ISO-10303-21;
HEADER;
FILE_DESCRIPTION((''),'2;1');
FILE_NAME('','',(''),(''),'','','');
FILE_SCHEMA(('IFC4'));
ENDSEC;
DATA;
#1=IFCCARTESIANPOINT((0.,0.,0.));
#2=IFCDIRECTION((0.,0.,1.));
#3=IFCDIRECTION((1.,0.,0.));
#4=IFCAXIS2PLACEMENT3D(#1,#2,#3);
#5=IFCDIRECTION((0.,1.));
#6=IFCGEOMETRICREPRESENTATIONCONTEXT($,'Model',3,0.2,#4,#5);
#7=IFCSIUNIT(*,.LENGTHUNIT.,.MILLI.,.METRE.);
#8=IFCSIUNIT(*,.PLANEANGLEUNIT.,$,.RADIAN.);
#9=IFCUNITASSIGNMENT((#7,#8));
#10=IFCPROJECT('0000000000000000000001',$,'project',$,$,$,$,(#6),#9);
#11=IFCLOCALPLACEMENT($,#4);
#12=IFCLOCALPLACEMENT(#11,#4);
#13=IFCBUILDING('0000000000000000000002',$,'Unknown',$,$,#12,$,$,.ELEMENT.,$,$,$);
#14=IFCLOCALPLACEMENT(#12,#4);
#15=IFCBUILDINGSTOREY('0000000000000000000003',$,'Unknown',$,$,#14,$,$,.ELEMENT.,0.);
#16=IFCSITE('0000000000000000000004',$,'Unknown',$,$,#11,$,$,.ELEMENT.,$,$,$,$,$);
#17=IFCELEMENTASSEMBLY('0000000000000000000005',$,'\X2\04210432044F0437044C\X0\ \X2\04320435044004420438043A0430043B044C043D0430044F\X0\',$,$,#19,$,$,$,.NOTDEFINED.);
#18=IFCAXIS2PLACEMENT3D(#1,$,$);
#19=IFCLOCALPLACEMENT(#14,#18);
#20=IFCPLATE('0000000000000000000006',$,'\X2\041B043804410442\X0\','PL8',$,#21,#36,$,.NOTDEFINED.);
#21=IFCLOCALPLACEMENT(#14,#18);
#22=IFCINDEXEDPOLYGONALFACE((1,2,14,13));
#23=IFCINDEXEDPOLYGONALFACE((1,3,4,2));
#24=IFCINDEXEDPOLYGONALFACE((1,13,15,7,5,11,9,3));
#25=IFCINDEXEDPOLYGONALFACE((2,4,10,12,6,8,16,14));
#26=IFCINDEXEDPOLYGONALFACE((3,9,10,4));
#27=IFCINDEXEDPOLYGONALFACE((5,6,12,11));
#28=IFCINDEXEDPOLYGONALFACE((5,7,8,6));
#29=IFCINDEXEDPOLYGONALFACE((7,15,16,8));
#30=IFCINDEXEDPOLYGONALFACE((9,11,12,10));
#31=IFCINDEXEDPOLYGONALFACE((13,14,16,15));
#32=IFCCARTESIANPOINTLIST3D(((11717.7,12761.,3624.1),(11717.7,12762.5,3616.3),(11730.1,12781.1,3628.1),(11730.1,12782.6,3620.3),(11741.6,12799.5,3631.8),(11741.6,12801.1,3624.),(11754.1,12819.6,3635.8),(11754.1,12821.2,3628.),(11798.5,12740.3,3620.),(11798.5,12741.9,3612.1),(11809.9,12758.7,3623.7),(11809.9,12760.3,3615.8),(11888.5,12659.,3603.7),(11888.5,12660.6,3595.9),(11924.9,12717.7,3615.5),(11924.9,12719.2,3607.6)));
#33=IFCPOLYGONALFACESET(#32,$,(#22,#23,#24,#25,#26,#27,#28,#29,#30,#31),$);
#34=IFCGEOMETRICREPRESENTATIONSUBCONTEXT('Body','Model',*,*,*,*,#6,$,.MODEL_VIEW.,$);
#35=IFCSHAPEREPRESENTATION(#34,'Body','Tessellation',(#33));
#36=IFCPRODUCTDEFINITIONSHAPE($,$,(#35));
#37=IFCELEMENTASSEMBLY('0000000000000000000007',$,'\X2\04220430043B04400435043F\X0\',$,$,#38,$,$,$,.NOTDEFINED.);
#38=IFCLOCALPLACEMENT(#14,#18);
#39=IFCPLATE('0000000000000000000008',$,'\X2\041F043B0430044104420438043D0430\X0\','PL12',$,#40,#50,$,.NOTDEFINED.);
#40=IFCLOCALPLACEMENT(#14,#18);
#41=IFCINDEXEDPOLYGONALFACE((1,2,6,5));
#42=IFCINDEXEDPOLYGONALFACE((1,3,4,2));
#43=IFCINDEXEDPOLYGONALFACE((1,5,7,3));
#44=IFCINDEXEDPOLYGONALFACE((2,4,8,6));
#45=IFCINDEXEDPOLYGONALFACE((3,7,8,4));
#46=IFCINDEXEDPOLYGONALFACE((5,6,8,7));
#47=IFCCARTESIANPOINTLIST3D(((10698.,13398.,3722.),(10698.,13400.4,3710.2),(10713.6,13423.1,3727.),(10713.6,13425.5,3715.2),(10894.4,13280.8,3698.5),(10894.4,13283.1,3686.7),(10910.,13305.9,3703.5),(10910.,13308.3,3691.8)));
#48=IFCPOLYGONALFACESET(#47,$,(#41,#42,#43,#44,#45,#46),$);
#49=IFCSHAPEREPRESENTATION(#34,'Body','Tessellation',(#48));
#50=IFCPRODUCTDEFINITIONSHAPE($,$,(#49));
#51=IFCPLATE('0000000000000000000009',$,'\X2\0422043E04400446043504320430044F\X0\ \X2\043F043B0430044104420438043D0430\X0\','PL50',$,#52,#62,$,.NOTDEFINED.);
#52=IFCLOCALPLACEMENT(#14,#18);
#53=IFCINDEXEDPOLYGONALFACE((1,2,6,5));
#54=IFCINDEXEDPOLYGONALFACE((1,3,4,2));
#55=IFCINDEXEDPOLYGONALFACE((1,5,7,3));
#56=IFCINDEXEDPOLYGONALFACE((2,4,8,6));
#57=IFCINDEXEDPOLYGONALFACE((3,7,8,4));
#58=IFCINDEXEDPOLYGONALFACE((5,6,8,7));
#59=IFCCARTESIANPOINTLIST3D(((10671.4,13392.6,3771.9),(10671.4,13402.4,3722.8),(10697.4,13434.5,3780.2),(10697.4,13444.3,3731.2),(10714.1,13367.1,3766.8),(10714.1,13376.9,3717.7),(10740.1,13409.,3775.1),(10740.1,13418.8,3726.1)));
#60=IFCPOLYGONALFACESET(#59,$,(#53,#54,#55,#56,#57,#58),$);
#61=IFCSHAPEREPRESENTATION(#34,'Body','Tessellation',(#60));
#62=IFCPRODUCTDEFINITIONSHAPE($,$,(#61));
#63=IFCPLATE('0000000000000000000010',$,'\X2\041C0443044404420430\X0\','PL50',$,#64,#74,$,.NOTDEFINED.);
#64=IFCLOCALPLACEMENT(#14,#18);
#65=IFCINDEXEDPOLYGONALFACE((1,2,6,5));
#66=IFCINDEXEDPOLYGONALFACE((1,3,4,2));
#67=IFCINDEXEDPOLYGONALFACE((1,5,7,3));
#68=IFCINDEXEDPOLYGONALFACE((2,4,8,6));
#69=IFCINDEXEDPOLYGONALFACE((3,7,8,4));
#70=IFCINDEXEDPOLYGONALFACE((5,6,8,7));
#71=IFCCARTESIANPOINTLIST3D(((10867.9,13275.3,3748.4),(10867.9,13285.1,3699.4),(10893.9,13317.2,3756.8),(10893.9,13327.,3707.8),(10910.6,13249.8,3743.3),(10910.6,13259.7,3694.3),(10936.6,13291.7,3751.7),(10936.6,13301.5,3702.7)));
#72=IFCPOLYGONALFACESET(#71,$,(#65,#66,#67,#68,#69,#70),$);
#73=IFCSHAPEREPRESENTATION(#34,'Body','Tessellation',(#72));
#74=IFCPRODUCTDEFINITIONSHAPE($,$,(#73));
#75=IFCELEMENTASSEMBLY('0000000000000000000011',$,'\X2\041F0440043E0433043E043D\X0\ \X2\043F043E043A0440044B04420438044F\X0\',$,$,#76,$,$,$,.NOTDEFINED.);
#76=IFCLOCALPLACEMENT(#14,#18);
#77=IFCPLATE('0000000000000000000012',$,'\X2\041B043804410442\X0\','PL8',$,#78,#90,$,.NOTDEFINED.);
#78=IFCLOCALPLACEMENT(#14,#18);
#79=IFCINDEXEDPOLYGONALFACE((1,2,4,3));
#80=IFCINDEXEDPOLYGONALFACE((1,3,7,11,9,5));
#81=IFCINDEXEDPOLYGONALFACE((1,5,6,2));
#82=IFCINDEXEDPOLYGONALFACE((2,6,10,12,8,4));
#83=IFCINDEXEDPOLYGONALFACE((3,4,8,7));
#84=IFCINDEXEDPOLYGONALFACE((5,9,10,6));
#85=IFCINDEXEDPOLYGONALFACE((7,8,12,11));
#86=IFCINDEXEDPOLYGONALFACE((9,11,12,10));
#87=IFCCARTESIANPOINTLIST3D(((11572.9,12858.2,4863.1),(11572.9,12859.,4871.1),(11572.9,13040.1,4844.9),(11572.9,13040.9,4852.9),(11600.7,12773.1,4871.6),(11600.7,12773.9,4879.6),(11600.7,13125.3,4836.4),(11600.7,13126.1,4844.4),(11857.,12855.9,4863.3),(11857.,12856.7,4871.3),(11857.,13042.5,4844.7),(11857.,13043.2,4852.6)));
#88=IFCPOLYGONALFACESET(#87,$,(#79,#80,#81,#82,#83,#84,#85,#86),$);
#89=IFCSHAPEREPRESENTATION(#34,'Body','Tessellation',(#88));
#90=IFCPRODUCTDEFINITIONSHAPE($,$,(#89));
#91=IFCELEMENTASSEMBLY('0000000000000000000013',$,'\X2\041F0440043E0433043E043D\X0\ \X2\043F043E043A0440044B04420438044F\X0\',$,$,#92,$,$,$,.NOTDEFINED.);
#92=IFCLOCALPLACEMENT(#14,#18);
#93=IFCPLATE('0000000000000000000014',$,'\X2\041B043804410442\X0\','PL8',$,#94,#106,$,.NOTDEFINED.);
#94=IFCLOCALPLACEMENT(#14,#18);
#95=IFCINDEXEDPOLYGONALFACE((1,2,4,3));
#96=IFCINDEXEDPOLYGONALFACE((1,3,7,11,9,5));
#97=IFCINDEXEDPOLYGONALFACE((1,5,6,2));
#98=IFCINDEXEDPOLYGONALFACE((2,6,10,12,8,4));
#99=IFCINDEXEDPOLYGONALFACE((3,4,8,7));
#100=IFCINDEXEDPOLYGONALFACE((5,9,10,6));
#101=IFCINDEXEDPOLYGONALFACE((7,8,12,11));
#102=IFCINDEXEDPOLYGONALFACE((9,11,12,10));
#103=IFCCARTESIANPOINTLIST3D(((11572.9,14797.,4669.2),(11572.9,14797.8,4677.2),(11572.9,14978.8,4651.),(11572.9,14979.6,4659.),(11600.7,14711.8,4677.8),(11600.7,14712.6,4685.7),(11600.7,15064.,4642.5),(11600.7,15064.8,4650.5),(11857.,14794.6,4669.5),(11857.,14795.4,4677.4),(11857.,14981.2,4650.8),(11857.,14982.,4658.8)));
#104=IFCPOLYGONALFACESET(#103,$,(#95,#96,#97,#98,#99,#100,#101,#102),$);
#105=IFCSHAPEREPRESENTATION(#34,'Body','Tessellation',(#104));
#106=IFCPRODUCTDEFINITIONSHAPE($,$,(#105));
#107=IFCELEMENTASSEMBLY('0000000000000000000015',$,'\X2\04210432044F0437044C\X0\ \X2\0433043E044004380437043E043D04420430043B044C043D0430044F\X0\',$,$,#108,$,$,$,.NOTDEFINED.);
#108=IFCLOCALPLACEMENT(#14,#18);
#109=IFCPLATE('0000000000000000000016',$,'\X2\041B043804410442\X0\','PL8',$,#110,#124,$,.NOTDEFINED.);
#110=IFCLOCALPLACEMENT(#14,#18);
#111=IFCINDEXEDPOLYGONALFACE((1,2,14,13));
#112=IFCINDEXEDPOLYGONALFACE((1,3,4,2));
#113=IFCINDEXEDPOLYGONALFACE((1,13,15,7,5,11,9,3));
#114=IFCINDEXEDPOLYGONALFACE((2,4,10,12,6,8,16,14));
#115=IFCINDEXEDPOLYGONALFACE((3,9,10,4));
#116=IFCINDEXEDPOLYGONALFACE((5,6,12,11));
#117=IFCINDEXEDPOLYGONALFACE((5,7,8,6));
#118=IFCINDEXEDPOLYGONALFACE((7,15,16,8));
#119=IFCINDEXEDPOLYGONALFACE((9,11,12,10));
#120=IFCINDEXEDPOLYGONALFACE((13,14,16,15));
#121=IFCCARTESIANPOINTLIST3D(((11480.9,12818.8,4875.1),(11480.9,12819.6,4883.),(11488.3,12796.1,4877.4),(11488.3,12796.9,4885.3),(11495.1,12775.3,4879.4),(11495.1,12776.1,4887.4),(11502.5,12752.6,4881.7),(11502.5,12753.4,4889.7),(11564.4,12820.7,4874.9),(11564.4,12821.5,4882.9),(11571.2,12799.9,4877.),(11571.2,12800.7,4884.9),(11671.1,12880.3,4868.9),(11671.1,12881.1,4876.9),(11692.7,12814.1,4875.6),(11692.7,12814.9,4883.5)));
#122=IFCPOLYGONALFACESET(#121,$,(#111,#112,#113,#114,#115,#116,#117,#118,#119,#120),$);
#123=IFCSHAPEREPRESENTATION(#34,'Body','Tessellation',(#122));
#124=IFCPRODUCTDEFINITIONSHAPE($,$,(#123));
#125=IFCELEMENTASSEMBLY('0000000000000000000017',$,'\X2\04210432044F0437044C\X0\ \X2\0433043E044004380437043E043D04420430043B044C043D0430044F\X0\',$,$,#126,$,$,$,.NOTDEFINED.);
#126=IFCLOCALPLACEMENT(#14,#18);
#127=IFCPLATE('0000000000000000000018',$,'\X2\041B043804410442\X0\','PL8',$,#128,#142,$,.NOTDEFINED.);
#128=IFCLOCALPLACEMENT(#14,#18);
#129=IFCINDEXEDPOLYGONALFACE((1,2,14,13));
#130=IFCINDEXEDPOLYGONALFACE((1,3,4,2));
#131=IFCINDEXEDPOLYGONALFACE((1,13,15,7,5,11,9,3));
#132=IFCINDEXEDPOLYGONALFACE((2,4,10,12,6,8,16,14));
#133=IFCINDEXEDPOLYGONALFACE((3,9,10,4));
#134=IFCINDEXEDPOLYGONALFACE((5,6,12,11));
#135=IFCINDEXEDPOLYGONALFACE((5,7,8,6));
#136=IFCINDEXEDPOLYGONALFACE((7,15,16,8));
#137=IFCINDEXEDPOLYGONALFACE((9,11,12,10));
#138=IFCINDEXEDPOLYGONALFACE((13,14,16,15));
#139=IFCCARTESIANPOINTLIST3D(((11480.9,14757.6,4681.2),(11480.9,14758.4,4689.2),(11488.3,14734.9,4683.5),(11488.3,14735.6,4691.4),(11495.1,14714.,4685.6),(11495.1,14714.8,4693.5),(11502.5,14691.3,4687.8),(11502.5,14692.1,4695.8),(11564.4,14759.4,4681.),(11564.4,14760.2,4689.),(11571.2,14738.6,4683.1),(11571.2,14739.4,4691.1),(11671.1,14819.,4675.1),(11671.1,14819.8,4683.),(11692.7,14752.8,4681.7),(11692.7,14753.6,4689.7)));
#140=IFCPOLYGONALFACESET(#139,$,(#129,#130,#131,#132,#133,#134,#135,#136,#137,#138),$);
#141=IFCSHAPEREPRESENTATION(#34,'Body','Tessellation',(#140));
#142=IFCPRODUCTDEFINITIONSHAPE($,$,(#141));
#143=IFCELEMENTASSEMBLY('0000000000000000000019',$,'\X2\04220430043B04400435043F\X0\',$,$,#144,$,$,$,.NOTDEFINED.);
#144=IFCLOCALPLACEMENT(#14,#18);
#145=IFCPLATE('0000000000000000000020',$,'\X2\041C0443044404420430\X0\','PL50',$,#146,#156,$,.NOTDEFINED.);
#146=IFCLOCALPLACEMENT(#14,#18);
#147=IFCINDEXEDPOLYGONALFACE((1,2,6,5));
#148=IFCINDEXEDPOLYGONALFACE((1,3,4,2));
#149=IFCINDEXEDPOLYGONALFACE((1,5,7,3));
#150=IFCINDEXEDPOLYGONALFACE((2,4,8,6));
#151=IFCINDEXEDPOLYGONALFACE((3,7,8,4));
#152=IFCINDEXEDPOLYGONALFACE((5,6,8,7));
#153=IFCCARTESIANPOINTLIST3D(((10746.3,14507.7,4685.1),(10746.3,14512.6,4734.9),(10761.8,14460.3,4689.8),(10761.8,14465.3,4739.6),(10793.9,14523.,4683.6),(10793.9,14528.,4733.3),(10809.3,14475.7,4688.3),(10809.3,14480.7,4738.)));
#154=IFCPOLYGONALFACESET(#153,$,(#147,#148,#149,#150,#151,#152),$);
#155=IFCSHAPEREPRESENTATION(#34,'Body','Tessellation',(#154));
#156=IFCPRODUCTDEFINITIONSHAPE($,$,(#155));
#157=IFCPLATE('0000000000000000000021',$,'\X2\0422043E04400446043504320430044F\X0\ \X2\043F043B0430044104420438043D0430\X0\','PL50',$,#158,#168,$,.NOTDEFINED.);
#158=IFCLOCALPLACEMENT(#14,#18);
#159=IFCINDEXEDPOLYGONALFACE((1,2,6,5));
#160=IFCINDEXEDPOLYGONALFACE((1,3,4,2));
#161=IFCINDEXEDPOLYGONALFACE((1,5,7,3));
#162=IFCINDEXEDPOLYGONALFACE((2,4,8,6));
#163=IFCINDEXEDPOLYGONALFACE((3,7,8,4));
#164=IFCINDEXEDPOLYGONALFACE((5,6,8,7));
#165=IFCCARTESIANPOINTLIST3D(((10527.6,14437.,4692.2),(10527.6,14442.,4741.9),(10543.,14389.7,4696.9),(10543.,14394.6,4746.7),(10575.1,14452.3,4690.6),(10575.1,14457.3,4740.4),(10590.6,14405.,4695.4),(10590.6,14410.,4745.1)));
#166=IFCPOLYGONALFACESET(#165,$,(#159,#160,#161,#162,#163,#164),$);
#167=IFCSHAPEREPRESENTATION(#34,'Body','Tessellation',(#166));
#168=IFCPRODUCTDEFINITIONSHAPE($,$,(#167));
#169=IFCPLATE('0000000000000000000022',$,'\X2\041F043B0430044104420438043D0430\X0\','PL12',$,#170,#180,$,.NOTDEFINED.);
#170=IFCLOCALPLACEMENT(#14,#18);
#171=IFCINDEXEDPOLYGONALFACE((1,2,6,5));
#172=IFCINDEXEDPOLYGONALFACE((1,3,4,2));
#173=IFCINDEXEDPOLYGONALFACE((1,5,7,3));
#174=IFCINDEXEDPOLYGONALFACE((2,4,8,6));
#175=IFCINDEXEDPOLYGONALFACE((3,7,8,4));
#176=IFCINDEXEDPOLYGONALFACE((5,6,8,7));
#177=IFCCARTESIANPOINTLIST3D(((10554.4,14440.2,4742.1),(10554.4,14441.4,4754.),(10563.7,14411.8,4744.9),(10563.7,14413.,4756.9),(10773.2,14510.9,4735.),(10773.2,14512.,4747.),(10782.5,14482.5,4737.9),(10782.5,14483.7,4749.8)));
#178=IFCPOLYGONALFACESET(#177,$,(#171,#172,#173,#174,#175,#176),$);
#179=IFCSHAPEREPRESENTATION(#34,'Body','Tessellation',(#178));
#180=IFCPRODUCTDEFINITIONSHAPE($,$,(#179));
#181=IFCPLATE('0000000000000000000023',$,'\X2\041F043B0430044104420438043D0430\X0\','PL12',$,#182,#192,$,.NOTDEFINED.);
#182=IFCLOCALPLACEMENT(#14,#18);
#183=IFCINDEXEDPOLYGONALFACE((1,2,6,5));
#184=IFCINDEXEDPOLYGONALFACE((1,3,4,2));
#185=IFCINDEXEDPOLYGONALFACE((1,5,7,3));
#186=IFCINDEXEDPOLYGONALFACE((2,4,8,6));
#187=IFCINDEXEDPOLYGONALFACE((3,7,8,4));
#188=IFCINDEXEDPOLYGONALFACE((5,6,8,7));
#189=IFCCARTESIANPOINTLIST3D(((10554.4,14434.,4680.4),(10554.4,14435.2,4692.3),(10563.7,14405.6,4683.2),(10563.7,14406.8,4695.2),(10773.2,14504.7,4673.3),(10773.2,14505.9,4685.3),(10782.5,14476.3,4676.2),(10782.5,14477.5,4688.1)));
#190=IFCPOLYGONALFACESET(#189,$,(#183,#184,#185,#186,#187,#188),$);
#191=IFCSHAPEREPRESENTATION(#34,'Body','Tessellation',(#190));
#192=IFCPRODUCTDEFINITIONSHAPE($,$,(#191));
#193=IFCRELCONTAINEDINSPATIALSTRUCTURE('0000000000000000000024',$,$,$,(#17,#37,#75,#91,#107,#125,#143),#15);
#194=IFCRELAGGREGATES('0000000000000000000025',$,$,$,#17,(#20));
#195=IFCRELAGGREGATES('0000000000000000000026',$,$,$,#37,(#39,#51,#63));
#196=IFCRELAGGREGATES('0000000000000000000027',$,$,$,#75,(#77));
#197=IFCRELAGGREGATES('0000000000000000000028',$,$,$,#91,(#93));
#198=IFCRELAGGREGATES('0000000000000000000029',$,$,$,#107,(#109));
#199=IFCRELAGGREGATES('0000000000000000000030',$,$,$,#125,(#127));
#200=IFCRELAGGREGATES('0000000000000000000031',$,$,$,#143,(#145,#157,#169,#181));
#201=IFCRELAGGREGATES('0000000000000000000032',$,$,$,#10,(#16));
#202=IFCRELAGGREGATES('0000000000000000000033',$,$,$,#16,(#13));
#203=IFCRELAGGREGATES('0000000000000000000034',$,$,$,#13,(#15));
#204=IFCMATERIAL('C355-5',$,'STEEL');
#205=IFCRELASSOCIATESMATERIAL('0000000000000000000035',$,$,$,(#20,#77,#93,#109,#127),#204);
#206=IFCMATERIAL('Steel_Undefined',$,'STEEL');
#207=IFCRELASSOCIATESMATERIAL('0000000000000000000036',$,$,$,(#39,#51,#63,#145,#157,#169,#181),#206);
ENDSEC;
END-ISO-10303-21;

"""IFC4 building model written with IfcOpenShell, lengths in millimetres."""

from ifc_helpers import new_model, si_unit, direction, frame, origin_with_axes, place, context, subcontext, project, spatial, line, indexed_curve, outline, extrude, material, element, aggregate, save


model = new_model("IFC4")

# Units and contexts
model_context = context("Model", 3, precision=0.2, world=origin_with_axes(), true_north=direction((0.0, 1.0)))
body_context = subcontext(model_context, "Body", "Model", "MODEL_VIEW")
ifc_project = project(units=[si_unit("LENGTHUNIT", "METRE", prefix="MILLI"), si_unit("PLANEANGLEUNIT", "RADIAN")], contexts=[model_context])

# Site, building, storey
site_placement = place(None, origin_with_axes())
site = spatial("IfcSite", under=ifc_project, at=site_placement, Name="Unknown", CompositionType="ELEMENT")
building_placement = place(site_placement, origin_with_axes())
building = spatial("IfcBuilding", under=site, at=building_placement, Name="Unknown", CompositionType="ELEMENT")
storey_placement = place(building_placement, origin_with_axes())
storey = spatial("IfcBuildingStorey", under=building, at=storey_placement, Name="Unknown", CompositionType="ELEMENT", Elevation=0.0)

# Element assembly, plate
assembly_1_placement = place(storey_placement, frame((10804.0, 13347.1, 3737.3), z_axis=(0.519802, 0.837697, 0.167539), x_axis=(0.854287, -0.509708, -0.101942)))
assembly_1 = element("IfcElementAssembly", 1, at=assembly_1_placement, inside=storey, Name="Связь вертикальная", PredefinedType="NOTDEFINED")
ifc_material_1 = material(Name="C355-5", Category="STEEL")
plate_1_placement = place(assembly_1_placement, frame((1090.8, 0.0, 35.0), z_axis=(0.0, 1.0, 0.0), x_axis=(1.0, 0.0, 0.0)))
plate_1 = element("IfcPlate", 2, at=plate_1_placement, material=ifc_material_1, Name="Лист", Description="PL8", PredefinedType="NOTDEFINED", context=body_context, shape_type="SolidModel", body=[
    extrude(outline(indexed_curve([(0.0, 0.0), (200.0, 0.0), (200.0, 70.0), (0.0, 70.0), (0.0, 46.0), (80.0, 46.0), (80.0, 24.0), (0.0, 24.0)], segments=[line(1, 2, 3, 4, 5, 6, 7, 8, 1)])), frame((0.0, 0.0, 4.0), z_axis=(0.0, 0.0, 1.0), x_axis=(1.0, 0.0, 0.0)), (0.0, 0.0, -1.0), 8.0),
])
aggregate(assembly_1, [plate_1])

# Element assembly, plates
assembly_2_placement = place(storey_placement, frame((10915.2, 13314.3, 3705.2), z_axis=(-0.854287, 0.509708, 0.101942), x_axis=(-0.519802, -0.837697, -0.167539)))
assembly_2 = element("IfcElementAssembly", 3, at=assembly_2_placement, inside=storey, Name="Талреп", PredefinedType="NOTDEFINED")
ifc_material_2 = material(Name="Steel_Undefined", Category="STEEL")
plate_2_placement = place(assembly_2_placement, frame((10.0, -6.0, 230.0), z_axis=(0.0, 1.0, 0.0), x_axis=(1.0, 0.0, 0.0)))
plate_2 = element("IfcPlate", 4, at=plate_2_placement, material=ifc_material_2, Name="Пластина", Description="PL12", PredefinedType="NOTDEFINED", context=body_context, shape_type="SolidModel", body=[
    extrude(outline(indexed_curve([(0.0, 0.0), (30.0, 0.0), (30.0, 230.0), (0.0, 230.0)], segments=[line(1, 2, 3, 4, 1)])), frame((0.0, 0.0, 6.0), z_axis=(0.0, 0.0, 1.0), x_axis=(1.0, 0.0, 0.0)), (0.0, 0.0, -1.0), 12.0),
])
plate_3_placement = place(assembly_2_placement, frame((0.0, 0.0, 230.0), z_axis=(0.0, 0.0, 1.0), x_axis=(1.0, 0.0, 0.0)))
plate_3 = element("IfcPlate", 5, at=plate_3_placement, material=ifc_material_2, Name="Торцевая пластина", Description="PL50", PredefinedType="NOTDEFINED", context=body_context, shape_type="SolidModel", body=[
    extrude(outline(indexed_curve([(0.0, 0.0), (50.0, 0.0), (50.0, 50.0), (0.0, 50.0)], segments=[line(1, 2, 3, 4, 1)])), frame((0.0, 0.0, 25.0), z_axis=(0.0, 0.0, 1.0), x_axis=(1.0, 0.0, 0.0)), (0.0, 0.0, -1.0), 50.0),
])
plate_4_placement = place(assembly_2_placement, origin_with_axes())
plate_4 = element("IfcPlate", 6, at=plate_4_placement, material=ifc_material_2, Name="Муфта", Description="PL50", PredefinedType="NOTDEFINED", context=body_context, shape_type="SolidModel", body=[
    extrude(outline(indexed_curve([(0.0, 0.0), (50.0, 0.0), (50.0, 50.0), (0.0, 50.0)], segments=[line(1, 2, 3, 4, 1)])), frame((0.0, 0.0, 25.0), z_axis=(0.0, 0.0, 1.0), x_axis=(1.0, 0.0, 0.0)), (0.0, 0.0, -1.0), 50.0),
])
aggregate(assembly_2, [plate_2, plate_3, plate_4])

# Element assemblies, plates
assembly_3_placement = place(storey_placement, frame((12000.0, 12949.6, 4858.0), z_axis=(0.0, -0.995037, 0.099504), x_axis=(-1.0, 0.0, 0.0)))
assembly_3 = element("IfcElementAssembly", 7, at=assembly_3_placement, inside=storey, Name="Прогон покрытия", PredefinedType="NOTDEFINED")
plate_5_placement = place(assembly_3_placement, frame((427.1, 0.0, 91.4), z_axis=(0.0, -1.0, 0.0), x_axis=(-0.308855, 0.0, 0.951109)))
plate_5 = element("IfcPlate", 8, at=plate_5_placement, material=ifc_material_1, Name="Лист", Description="PL8", PredefinedType="NOTDEFINED", context=body_context, shape_type="SolidModel", body=[
    extrude(outline(indexed_curve([(0.0, 0.0), (90.0, 0.0), (90.0, 269.5), (-88.3, 327.4), (-246.6, 109.3), (-173.8, 56.4)], segments=[line(1, 2, 3, 4, 5, 6, 1)])), frame((0.0, 0.0, 4.0), z_axis=(0.0, 0.0, 1.0), x_axis=(1.0, 0.0, 0.0)), (0.0, 0.0, -1.0), 8.0),
])
aggregate(assembly_3, [plate_5])
assembly_4_placement = place(storey_placement, frame((12000.0, 14888.3, 4664.1), z_axis=(0.0, -0.995037, 0.099504), x_axis=(-1.0, 0.0, 0.0)))
assembly_4 = element("IfcElementAssembly", 9, at=assembly_4_placement, inside=storey, Name="Прогон покрытия", PredefinedType="NOTDEFINED")
plate_6_placement = place(assembly_4_placement, frame((427.1, 0.0, 91.4), z_axis=(0.0, -1.0, 0.0), x_axis=(-0.308855, 0.0, 0.951109)))
plate_6 = element("IfcPlate", 10, at=plate_6_placement, material=ifc_material_1, Name="Лист", Description="PL8", PredefinedType="NOTDEFINED", context=body_context, shape_type="SolidModel", body=[
    extrude(outline(indexed_curve([(0.0, 0.0), (90.0, 0.0), (90.0, 269.5), (-88.3, 327.4), (-246.6, 109.3), (-173.8, 56.4)], segments=[line(1, 2, 3, 4, 5, 6, 1)])), frame((0.0, 0.0, 4.0), z_axis=(0.0, 0.0, 1.0), x_axis=(1.0, 0.0, 0.0)), (0.0, 0.0, -1.0), 8.0),
])
aggregate(assembly_4, [plate_6])
assembly_5_placement = place(storey_placement, frame((10668.4, 12520.1, 4909.0), z_axis=(0.308855, -0.946389, 0.094639), x_axis=(0.951109, 0.307322, -0.030732)))
assembly_5 = element("IfcElementAssembly", 11, at=assembly_5_placement, inside=storey, Name="Связь горизонтальная", PredefinedType="NOTDEFINED")
plate_7_placement = place(assembly_5_placement, frame((865.6, 0.0, -35.0), z_axis=(0.0, -1.0, 0.0), x_axis=(1.0, 0.0, 0.0)))
plate_7 = element("IfcPlate", 12, at=plate_7_placement, material=ifc_material_1, Name="Лист", Description="PL8", PredefinedType="NOTDEFINED", context=body_context, shape_type="SolidModel", body=[
    extrude(outline(indexed_curve([(0.0, 0.0), (200.0, 0.0), (200.0, 70.0), (0.0, 70.0), (0.0, 46.0), (80.0, 46.0), (80.0, 24.0), (0.0, 24.0)], segments=[line(1, 2, 3, 4, 5, 6, 7, 8, 1)])), frame((0.0, 0.0, 4.0), z_axis=(0.0, 0.0, 1.0), x_axis=(1.0, 0.0, 0.0)), (0.0, 0.0, -1.0), 8.0),
])
aggregate(assembly_5, [plate_7])
assembly_6_placement = place(storey_placement, frame((10668.4, 14458.8, 4715.1), z_axis=(0.308855, -0.946389, 0.094639), x_axis=(0.951109, 0.307322, -0.030732)))
assembly_6 = element("IfcElementAssembly", 13, at=assembly_6_placement, inside=storey, Name="Связь горизонтальная", PredefinedType="NOTDEFINED")
plate_8_placement = place(assembly_6_placement, frame((865.6, 0.0, -35.0), z_axis=(0.0, -1.0, 0.0), x_axis=(1.0, 0.0, 0.0)))
plate_8 = element("IfcPlate", 14, at=plate_8_placement, material=ifc_material_1, Name="Лист", Description="PL8", PredefinedType="NOTDEFINED", context=body_context, shape_type="SolidModel", body=[
    extrude(outline(indexed_curve([(0.0, 0.0), (200.0, 0.0), (200.0, 70.0), (0.0, 70.0), (0.0, 46.0), (80.0, 46.0), (80.0, 24.0), (0.0, 24.0)], segments=[line(1, 2, 3, 4, 5, 6, 7, 8, 1)])), frame((0.0, 0.0, 4.0), z_axis=(0.0, 0.0, 1.0), x_axis=(1.0, 0.0, 0.0)), (0.0, 0.0, -1.0), 8.0),
])
aggregate(assembly_6, [plate_8])

# Element assembly, plates
assembly_7_placement = place(storey_placement, frame((10785.5, 14473.0, 4738.8), z_axis=(-0.951109, -0.307322, 0.030732), x_axis=(-0.308855, 0.946389, -0.094639)))
assembly_7 = element("IfcElementAssembly", 15, at=assembly_7_placement, inside=storey, Name="Талреп", PredefinedType="NOTDEFINED")
plate_9_placement = place(assembly_7_placement, origin_with_axes())
plate_9 = element("IfcPlate", 16, at=plate_9_placement, material=ifc_material_2, Name="Муфта", Description="PL50", PredefinedType="NOTDEFINED", context=body_context, shape_type="SolidModel", body=[
    extrude(outline(indexed_curve([(0.0, 0.0), (50.0, 0.0), (50.0, 50.0), (0.0, 50.0)], segments=[line(1, 2, 3, 4, 1)])), frame((0.0, 0.0, 25.0), z_axis=(0.0, 0.0, 1.0), x_axis=(1.0, 0.0, 0.0)), (0.0, 0.0, -1.0), 50.0),
])
plate_10_placement = place(assembly_7_placement, frame((0.0, 0.0, 230.0), z_axis=(0.0, 0.0, 1.0), x_axis=(1.0, 0.0, 0.0)))
plate_10 = element("IfcPlate", 17, at=plate_10_placement, material=ifc_material_2, Name="Торцевая пластина", Description="PL50", PredefinedType="NOTDEFINED", context=body_context, shape_type="SolidModel", body=[
    extrude(outline(indexed_curve([(0.0, 0.0), (50.0, 0.0), (50.0, 50.0), (0.0, 50.0)], segments=[line(1, 2, 3, 4, 1)])), frame((0.0, 0.0, 25.0), z_axis=(0.0, 0.0, 1.0), x_axis=(1.0, 0.0, 0.0)), (0.0, 0.0, -1.0), 50.0),
])
plate_11_placement = place(assembly_7_placement, frame((10.0, -6.0, 230.0), z_axis=(0.0, 1.0, 0.0), x_axis=(1.0, 0.0, 0.0)))
plate_11 = element("IfcPlate", 18, at=plate_11_placement, material=ifc_material_2, Name="Пластина", Description="PL12", PredefinedType="NOTDEFINED", context=body_context, shape_type="SolidModel", body=[
    extrude(outline(indexed_curve([(0.0, 0.0), (30.0, 0.0), (30.0, 230.0), (0.0, 230.0)], segments=[line(1, 2, 3, 4, 1)])), frame((0.0, 0.0, 6.0), z_axis=(0.0, 0.0, 1.0), x_axis=(1.0, 0.0, 0.0)), (0.0, 0.0, -1.0), 12.0),
])
plate_12_placement = place(assembly_7_placement, frame((10.0, 56.0, 230.0), z_axis=(0.0, 1.0, 0.0), x_axis=(1.0, 0.0, 0.0)))
plate_12 = element("IfcPlate", 19, at=plate_12_placement, material=ifc_material_2, Name="Пластина", Description="PL12", PredefinedType="NOTDEFINED", context=body_context, shape_type="SolidModel", body=[
    extrude(outline(indexed_curve([(0.0, 0.0), (30.0, 0.0), (30.0, 230.0), (0.0, 230.0)], segments=[line(1, 2, 3, 4, 1)])), frame((0.0, 0.0, 6.0), z_axis=(0.0, 0.0, 1.0), x_axis=(1.0, 0.0, 0.0)), (0.0, 0.0, -1.0), 12.0),
])
aggregate(assembly_7, [plate_9, plate_10, plate_11, plate_12])

save(model, "model.ifc")
